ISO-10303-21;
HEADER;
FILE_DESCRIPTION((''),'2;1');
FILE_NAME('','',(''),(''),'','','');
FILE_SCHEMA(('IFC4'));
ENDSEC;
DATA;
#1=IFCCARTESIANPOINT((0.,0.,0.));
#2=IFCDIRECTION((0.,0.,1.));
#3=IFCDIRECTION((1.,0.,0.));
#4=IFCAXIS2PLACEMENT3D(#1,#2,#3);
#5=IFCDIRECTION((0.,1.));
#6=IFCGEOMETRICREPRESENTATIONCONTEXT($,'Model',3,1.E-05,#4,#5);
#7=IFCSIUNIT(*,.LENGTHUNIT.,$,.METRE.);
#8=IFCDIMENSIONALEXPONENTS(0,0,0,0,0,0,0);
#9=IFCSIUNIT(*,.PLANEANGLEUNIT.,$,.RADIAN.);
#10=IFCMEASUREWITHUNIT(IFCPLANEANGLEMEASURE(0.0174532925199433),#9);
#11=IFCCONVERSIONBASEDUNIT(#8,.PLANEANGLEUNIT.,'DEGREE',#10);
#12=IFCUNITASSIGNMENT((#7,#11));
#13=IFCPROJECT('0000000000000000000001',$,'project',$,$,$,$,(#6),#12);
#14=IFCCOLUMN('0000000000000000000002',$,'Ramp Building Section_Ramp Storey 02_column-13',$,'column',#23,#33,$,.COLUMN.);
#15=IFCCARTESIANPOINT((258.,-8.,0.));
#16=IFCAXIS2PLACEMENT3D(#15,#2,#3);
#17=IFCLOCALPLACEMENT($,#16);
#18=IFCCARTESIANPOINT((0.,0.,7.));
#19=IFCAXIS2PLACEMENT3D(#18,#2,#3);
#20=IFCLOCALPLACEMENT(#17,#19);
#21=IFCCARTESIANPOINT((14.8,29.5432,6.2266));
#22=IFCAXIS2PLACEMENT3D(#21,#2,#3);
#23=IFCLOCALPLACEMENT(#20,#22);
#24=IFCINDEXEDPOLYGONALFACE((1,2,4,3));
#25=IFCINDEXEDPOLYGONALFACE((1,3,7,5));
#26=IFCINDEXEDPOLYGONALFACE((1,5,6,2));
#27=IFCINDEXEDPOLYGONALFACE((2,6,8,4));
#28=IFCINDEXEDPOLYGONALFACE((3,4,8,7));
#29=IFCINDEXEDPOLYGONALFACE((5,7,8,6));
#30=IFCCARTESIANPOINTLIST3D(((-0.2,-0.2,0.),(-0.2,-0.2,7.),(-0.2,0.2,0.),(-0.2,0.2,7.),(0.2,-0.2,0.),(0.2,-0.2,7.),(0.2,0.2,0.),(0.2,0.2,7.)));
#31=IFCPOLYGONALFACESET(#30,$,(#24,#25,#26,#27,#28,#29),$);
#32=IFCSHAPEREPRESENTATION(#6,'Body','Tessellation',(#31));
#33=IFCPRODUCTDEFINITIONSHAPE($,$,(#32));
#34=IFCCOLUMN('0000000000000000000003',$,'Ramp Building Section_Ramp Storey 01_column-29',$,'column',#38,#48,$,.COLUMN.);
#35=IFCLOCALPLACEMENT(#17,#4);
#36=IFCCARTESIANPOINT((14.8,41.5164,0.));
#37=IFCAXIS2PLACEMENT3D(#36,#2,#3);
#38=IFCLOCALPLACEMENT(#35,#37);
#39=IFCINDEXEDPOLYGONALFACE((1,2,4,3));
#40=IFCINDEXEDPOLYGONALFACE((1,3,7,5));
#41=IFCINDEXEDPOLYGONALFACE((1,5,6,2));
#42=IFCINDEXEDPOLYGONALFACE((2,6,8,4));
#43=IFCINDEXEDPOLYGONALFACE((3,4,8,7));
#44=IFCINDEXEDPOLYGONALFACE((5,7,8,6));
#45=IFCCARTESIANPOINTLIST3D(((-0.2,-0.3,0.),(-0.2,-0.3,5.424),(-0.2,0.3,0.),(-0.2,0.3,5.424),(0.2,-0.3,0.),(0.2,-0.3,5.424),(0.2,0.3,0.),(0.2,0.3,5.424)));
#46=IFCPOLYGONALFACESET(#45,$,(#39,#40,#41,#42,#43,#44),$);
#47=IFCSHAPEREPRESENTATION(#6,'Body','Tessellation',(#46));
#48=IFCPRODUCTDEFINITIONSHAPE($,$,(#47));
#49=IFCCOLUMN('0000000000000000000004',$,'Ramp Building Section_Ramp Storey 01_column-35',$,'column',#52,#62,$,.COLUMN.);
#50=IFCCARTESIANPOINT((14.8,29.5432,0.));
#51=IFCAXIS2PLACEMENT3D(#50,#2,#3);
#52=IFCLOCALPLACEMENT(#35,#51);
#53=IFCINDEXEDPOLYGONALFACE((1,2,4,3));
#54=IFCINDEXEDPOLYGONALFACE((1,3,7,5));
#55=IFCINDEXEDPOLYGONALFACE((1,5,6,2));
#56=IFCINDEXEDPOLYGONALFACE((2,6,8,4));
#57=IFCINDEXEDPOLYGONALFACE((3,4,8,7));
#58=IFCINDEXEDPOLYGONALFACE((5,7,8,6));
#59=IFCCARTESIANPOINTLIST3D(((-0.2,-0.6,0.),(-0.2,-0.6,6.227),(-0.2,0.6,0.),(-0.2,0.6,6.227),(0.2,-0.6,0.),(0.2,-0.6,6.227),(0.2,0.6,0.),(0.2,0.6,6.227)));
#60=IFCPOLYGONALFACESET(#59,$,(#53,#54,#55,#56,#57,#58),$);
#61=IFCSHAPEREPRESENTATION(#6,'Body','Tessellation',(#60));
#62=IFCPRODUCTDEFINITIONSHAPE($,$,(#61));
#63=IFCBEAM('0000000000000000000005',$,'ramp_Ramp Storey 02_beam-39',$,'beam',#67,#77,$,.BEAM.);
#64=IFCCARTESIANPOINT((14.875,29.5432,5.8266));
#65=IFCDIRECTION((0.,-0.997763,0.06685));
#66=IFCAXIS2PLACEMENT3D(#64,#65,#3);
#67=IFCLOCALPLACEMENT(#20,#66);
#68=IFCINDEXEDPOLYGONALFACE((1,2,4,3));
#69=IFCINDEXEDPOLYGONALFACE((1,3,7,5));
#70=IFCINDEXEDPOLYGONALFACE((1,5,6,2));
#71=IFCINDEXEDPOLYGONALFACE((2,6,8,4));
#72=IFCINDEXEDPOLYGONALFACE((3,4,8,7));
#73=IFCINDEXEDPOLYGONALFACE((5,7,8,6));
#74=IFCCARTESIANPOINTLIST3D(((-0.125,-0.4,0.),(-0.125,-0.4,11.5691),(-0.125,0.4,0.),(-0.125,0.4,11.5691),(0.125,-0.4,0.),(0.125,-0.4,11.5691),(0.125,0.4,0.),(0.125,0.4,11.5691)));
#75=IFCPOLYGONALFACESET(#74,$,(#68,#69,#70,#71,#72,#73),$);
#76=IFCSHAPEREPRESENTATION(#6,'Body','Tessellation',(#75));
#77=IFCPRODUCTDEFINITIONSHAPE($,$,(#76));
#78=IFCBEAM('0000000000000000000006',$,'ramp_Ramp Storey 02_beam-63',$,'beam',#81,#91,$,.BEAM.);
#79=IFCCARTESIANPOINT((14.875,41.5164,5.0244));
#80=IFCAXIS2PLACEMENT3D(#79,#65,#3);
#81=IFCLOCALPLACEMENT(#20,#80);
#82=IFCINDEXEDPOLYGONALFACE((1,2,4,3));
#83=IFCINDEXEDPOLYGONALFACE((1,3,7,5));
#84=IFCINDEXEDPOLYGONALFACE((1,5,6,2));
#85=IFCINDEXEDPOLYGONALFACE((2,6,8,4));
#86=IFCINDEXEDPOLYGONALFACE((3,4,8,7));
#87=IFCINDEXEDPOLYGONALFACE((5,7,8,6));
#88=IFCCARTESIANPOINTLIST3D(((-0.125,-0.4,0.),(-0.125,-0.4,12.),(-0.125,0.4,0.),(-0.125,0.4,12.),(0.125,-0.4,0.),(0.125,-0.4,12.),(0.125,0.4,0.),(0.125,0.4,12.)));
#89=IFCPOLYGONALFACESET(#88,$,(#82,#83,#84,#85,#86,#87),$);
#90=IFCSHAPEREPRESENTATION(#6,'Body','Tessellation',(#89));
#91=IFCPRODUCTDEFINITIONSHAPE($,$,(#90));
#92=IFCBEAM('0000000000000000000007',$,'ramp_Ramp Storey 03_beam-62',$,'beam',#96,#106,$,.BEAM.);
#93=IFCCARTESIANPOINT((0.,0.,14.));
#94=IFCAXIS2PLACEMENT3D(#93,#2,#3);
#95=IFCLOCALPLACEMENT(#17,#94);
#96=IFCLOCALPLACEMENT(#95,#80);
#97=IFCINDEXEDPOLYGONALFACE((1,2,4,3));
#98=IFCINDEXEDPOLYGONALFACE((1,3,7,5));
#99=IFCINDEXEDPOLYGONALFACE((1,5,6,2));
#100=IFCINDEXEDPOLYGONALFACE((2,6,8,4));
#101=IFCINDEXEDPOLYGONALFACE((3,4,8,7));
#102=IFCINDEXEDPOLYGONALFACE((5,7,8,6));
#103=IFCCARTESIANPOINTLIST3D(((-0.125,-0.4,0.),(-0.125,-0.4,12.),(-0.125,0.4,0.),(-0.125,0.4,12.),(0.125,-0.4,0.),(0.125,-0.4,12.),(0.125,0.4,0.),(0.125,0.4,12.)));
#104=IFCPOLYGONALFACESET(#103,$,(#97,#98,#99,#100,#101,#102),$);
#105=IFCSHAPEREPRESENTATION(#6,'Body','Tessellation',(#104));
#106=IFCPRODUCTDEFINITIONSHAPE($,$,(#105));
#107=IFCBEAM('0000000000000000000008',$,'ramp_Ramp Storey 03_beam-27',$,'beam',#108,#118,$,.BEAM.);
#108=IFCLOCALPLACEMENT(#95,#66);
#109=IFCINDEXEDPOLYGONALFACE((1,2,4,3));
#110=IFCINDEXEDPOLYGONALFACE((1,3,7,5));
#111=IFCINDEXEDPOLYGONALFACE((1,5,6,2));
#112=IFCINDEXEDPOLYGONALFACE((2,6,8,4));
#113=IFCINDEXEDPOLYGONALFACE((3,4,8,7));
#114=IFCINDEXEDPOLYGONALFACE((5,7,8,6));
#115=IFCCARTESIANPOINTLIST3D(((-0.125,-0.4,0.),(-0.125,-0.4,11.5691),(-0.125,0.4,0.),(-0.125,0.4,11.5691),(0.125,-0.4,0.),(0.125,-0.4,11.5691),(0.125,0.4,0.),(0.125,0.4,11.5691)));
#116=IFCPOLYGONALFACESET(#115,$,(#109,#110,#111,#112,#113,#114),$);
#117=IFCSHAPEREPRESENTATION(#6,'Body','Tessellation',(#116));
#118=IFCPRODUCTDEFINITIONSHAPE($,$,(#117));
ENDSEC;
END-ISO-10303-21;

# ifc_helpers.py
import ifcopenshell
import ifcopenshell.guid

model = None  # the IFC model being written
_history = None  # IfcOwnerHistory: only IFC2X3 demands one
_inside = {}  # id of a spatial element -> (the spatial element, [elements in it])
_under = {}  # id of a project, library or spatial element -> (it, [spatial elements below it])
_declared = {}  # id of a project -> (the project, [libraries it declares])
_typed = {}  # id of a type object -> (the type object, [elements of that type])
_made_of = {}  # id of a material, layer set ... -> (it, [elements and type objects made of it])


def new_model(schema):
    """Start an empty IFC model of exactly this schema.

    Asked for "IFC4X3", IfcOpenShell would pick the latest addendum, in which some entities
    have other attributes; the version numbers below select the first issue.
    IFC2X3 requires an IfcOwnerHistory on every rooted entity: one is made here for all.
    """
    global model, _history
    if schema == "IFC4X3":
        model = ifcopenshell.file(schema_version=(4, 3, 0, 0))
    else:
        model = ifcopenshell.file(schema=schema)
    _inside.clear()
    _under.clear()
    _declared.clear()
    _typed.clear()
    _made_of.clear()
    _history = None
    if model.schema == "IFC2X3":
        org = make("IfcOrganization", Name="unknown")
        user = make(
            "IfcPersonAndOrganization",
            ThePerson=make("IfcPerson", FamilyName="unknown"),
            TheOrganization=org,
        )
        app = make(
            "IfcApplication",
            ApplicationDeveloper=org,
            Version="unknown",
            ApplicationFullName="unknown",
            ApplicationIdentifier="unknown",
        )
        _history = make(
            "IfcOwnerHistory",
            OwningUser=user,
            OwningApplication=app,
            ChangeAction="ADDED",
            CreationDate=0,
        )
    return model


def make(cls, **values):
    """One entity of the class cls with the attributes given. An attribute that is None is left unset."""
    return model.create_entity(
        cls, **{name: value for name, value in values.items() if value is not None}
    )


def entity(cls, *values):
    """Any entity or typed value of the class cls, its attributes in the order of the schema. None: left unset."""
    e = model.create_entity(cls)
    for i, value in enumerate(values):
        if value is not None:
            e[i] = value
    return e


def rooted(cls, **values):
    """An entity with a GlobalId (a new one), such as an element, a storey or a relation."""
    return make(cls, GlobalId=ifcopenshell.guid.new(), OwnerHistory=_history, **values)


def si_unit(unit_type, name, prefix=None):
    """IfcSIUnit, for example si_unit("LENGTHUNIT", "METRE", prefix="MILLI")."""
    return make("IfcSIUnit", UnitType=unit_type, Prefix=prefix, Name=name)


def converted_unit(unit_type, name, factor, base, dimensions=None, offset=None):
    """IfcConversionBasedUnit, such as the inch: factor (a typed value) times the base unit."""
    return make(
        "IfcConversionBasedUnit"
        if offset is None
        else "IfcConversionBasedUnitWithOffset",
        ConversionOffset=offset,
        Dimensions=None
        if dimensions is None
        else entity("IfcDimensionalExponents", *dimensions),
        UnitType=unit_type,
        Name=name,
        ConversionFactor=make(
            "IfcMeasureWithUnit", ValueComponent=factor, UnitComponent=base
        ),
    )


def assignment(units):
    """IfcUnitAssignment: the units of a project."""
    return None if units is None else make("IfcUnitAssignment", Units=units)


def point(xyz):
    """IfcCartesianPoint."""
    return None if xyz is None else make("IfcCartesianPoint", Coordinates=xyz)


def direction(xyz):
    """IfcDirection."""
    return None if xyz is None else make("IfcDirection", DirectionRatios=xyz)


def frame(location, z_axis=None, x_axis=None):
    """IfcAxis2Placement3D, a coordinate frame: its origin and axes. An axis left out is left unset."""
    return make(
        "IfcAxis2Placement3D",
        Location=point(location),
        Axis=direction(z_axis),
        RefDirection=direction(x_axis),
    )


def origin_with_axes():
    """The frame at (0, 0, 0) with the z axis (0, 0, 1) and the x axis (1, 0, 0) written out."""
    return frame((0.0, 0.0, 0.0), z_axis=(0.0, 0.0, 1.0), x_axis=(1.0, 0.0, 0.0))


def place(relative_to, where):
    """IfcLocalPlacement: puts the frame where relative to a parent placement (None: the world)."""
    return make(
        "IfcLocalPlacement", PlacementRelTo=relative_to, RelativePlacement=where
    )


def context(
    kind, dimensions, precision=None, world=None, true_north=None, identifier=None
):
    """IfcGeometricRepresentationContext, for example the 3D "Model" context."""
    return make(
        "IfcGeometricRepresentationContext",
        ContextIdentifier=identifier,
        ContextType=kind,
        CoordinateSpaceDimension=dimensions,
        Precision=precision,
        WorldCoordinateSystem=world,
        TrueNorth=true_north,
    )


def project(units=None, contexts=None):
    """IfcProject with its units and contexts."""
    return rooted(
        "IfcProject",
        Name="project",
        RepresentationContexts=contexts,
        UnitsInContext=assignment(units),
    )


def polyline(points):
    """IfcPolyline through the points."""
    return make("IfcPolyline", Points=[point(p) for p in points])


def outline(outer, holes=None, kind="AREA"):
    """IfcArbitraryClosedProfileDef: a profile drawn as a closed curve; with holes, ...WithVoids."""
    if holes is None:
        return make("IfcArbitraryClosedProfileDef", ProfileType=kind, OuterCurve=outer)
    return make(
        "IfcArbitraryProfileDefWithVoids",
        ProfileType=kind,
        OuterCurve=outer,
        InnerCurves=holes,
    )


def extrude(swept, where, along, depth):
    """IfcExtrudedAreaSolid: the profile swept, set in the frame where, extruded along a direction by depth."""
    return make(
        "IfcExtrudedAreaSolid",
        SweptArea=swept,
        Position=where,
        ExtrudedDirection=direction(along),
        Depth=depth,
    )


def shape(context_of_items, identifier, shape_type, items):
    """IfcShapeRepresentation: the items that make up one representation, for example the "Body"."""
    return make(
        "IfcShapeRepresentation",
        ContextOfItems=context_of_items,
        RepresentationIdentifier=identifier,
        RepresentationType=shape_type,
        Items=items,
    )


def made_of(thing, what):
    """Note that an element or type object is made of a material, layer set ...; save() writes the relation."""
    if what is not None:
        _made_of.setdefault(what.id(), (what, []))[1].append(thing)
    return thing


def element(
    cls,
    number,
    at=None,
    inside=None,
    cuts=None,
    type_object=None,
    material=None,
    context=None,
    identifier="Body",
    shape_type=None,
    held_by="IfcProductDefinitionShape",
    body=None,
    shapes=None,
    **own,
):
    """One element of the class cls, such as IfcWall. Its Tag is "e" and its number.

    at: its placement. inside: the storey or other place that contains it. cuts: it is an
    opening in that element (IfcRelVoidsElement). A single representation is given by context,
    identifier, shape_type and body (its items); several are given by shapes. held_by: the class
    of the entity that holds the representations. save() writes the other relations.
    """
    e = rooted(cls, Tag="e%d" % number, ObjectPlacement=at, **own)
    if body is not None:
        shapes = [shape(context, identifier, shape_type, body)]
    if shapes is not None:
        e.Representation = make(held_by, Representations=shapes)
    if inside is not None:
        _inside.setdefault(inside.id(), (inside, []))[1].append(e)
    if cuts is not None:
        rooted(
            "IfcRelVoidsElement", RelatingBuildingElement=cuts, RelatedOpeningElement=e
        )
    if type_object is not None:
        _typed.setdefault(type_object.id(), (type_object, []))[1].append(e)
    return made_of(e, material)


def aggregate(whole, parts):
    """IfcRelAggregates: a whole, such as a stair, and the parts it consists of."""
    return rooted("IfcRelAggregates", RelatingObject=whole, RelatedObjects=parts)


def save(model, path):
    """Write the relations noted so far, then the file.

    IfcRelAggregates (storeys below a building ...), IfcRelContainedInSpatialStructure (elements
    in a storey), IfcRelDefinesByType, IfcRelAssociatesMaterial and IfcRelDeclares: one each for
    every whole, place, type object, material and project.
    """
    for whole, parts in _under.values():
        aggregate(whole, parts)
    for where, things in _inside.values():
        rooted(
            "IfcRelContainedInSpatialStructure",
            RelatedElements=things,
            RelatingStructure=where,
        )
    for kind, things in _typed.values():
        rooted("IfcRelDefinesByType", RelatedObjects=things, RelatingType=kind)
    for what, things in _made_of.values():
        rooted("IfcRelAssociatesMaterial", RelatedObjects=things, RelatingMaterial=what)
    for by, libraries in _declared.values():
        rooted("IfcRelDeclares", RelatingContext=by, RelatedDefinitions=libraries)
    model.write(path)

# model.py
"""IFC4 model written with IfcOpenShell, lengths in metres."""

from ifc_helpers import new_model, entity, si_unit, converted_unit, direction, frame, origin_with_axes, place, context, project, polyline, outline, extrude, element, save


model = new_model("IFC4")

# Units and contexts
model_context = context("Model", 3, precision=1e-05, world=origin_with_axes(), true_north=direction((0.0, 1.0)))
ifc_project = project(units=[si_unit("LENGTHUNIT", "METRE"), converted_unit("PLANEANGLEUNIT", "DEGREE", entity("IfcPlaneAngleMeasure", 0.0174532925199433), si_unit("PLANEANGLEUNIT", "RADIAN"), dimensions=[0, 0, 0, 0, 0, 0, 0])], contexts=[model_context])

# Shared definitions
placement_1 = place(None, frame((258.0, -8.0, 0.0), z_axis=(0.0, 0.0, 1.0), x_axis=(1.0, 0.0, 0.0)))
placement_2 = place(placement_1, origin_with_axes())

# Columns
placement_3 = place(placement_1, frame((0.0, 0.0, 7.0), z_axis=(0.0, 0.0, 1.0), x_axis=(1.0, 0.0, 0.0)))
column_1_placement = place(placement_3, frame((14.8, 29.5432, 6.2266), z_axis=(0.0, 0.0, 1.0), x_axis=(1.0, 0.0, 0.0)))
element("IfcColumn", 1, at=column_1_placement, Name="Ramp Building Section_Ramp Storey 02_column-13", ObjectType="column", PredefinedType="COLUMN", context=model_context, body=[
    extrude(outline(polyline([(-0.2, -0.2, 0.0), (0.2, -0.2, 0.0), (0.2, 0.2, 0.0), (-0.2, 0.2, 0.0), (-0.2, -0.2, 0.0)])), origin_with_axes(), (0.0, 0.0, 1.0), 7.0),
])
column_2_placement = place(placement_2, frame((14.8, 41.5164, 0.0), z_axis=(0.0, 0.0, 1.0), x_axis=(1.0, 0.0, 0.0)))
element("IfcColumn", 2, at=column_2_placement, Name="Ramp Building Section_Ramp Storey 01_column-29", ObjectType="column", PredefinedType="COLUMN", context=model_context, body=[
    extrude(outline(polyline([(-0.2, -0.3, 0.0), (0.2, -0.3, 0.0), (0.2, 0.3, 0.0), (-0.2, 0.3, 0.0), (-0.2, -0.3, 0.0)])), origin_with_axes(), (0.0, 0.0, 1.0), 5.424),
])
column_3_placement = place(placement_2, frame((14.8, 29.5432, 0.0), z_axis=(0.0, 0.0, 1.0), x_axis=(1.0, 0.0, 0.0)))
element("IfcColumn", 3, at=column_3_placement, Name="Ramp Building Section_Ramp Storey 01_column-35", ObjectType="column", PredefinedType="COLUMN", context=model_context, body=[
    extrude(outline(polyline([(-0.2, -0.6, 0.0), (0.2, -0.6, 0.0), (0.2, 0.6, 0.0), (-0.2, 0.6, 0.0), (-0.2, -0.6, 0.0)])), origin_with_axes(), (0.0, 0.0, 1.0), 6.227),
])

# Beams
beam_1_placement = place(placement_3, frame((14.875, 29.5432, 5.8266), z_axis=(0.0, -0.997763, 0.06685), x_axis=(1.0, 0.0, 0.0)))
element("IfcBeam", 4, at=beam_1_placement, Name="ramp_Ramp Storey 02_beam-39", ObjectType="beam", PredefinedType="BEAM", context=model_context, body=[
    extrude(outline(polyline([(0.125, 0.4, 0.0), (-0.125, 0.4, 0.0), (-0.125, -0.4, 0.0), (0.125, -0.4, 0.0), (0.125, 0.4, 0.0)])), origin_with_axes(), (0.0, 0.0, 1.0), 11.5691),
])
beam_2_placement = place(placement_3, frame((14.875, 41.5164, 5.0244), z_axis=(0.0, -0.997763, 0.06685), x_axis=(1.0, 0.0, 0.0)))
element("IfcBeam", 5, at=beam_2_placement, Name="ramp_Ramp Storey 02_beam-63", ObjectType="beam", PredefinedType="BEAM", context=model_context, body=[
    extrude(outline(polyline([(0.125, 0.4, 0.0), (-0.125, 0.4, 0.0), (-0.125, -0.4, 0.0), (0.125, -0.4, 0.0), (0.125, 0.4, 0.0)])), origin_with_axes(), (0.0, 0.0, 1.0), 12.0),
])
placement_4 = place(placement_1, frame((0.0, 0.0, 14.0), z_axis=(0.0, 0.0, 1.0), x_axis=(1.0, 0.0, 0.0)))
beam_3_placement = place(placement_4, frame((14.875, 41.5164, 5.0244), z_axis=(0.0, -0.997763, 0.06685), x_axis=(1.0, 0.0, 0.0)))
element("IfcBeam", 6, at=beam_3_placement, Name="ramp_Ramp Storey 03_beam-62", ObjectType="beam", PredefinedType="BEAM", context=model_context, body=[
    extrude(outline(polyline([(0.125, 0.4, 0.0), (-0.125, 0.4, 0.0), (-0.125, -0.4, 0.0), (0.125, -0.4, 0.0), (0.125, 0.4, 0.0)])), origin_with_axes(), (0.0, 0.0, 1.0), 12.0),
])
beam_4_placement = place(placement_4, frame((14.875, 29.5432, 5.8266), z_axis=(0.0, -0.997763, 0.06685), x_axis=(1.0, 0.0, 0.0)))
element("IfcBeam", 7, at=beam_4_placement, Name="ramp_Ramp Storey 03_beam-27", ObjectType="beam", PredefinedType="BEAM", context=model_context, body=[
    extrude(outline(polyline([(0.125, 0.4, 0.0), (-0.125, 0.4, 0.0), (-0.125, -0.4, 0.0), (0.125, -0.4, 0.0), (0.125, 0.4, 0.0)])), origin_with_axes(), (0.0, 0.0, 1.0), 11.5691),
])

save(model, "model.ifc")
